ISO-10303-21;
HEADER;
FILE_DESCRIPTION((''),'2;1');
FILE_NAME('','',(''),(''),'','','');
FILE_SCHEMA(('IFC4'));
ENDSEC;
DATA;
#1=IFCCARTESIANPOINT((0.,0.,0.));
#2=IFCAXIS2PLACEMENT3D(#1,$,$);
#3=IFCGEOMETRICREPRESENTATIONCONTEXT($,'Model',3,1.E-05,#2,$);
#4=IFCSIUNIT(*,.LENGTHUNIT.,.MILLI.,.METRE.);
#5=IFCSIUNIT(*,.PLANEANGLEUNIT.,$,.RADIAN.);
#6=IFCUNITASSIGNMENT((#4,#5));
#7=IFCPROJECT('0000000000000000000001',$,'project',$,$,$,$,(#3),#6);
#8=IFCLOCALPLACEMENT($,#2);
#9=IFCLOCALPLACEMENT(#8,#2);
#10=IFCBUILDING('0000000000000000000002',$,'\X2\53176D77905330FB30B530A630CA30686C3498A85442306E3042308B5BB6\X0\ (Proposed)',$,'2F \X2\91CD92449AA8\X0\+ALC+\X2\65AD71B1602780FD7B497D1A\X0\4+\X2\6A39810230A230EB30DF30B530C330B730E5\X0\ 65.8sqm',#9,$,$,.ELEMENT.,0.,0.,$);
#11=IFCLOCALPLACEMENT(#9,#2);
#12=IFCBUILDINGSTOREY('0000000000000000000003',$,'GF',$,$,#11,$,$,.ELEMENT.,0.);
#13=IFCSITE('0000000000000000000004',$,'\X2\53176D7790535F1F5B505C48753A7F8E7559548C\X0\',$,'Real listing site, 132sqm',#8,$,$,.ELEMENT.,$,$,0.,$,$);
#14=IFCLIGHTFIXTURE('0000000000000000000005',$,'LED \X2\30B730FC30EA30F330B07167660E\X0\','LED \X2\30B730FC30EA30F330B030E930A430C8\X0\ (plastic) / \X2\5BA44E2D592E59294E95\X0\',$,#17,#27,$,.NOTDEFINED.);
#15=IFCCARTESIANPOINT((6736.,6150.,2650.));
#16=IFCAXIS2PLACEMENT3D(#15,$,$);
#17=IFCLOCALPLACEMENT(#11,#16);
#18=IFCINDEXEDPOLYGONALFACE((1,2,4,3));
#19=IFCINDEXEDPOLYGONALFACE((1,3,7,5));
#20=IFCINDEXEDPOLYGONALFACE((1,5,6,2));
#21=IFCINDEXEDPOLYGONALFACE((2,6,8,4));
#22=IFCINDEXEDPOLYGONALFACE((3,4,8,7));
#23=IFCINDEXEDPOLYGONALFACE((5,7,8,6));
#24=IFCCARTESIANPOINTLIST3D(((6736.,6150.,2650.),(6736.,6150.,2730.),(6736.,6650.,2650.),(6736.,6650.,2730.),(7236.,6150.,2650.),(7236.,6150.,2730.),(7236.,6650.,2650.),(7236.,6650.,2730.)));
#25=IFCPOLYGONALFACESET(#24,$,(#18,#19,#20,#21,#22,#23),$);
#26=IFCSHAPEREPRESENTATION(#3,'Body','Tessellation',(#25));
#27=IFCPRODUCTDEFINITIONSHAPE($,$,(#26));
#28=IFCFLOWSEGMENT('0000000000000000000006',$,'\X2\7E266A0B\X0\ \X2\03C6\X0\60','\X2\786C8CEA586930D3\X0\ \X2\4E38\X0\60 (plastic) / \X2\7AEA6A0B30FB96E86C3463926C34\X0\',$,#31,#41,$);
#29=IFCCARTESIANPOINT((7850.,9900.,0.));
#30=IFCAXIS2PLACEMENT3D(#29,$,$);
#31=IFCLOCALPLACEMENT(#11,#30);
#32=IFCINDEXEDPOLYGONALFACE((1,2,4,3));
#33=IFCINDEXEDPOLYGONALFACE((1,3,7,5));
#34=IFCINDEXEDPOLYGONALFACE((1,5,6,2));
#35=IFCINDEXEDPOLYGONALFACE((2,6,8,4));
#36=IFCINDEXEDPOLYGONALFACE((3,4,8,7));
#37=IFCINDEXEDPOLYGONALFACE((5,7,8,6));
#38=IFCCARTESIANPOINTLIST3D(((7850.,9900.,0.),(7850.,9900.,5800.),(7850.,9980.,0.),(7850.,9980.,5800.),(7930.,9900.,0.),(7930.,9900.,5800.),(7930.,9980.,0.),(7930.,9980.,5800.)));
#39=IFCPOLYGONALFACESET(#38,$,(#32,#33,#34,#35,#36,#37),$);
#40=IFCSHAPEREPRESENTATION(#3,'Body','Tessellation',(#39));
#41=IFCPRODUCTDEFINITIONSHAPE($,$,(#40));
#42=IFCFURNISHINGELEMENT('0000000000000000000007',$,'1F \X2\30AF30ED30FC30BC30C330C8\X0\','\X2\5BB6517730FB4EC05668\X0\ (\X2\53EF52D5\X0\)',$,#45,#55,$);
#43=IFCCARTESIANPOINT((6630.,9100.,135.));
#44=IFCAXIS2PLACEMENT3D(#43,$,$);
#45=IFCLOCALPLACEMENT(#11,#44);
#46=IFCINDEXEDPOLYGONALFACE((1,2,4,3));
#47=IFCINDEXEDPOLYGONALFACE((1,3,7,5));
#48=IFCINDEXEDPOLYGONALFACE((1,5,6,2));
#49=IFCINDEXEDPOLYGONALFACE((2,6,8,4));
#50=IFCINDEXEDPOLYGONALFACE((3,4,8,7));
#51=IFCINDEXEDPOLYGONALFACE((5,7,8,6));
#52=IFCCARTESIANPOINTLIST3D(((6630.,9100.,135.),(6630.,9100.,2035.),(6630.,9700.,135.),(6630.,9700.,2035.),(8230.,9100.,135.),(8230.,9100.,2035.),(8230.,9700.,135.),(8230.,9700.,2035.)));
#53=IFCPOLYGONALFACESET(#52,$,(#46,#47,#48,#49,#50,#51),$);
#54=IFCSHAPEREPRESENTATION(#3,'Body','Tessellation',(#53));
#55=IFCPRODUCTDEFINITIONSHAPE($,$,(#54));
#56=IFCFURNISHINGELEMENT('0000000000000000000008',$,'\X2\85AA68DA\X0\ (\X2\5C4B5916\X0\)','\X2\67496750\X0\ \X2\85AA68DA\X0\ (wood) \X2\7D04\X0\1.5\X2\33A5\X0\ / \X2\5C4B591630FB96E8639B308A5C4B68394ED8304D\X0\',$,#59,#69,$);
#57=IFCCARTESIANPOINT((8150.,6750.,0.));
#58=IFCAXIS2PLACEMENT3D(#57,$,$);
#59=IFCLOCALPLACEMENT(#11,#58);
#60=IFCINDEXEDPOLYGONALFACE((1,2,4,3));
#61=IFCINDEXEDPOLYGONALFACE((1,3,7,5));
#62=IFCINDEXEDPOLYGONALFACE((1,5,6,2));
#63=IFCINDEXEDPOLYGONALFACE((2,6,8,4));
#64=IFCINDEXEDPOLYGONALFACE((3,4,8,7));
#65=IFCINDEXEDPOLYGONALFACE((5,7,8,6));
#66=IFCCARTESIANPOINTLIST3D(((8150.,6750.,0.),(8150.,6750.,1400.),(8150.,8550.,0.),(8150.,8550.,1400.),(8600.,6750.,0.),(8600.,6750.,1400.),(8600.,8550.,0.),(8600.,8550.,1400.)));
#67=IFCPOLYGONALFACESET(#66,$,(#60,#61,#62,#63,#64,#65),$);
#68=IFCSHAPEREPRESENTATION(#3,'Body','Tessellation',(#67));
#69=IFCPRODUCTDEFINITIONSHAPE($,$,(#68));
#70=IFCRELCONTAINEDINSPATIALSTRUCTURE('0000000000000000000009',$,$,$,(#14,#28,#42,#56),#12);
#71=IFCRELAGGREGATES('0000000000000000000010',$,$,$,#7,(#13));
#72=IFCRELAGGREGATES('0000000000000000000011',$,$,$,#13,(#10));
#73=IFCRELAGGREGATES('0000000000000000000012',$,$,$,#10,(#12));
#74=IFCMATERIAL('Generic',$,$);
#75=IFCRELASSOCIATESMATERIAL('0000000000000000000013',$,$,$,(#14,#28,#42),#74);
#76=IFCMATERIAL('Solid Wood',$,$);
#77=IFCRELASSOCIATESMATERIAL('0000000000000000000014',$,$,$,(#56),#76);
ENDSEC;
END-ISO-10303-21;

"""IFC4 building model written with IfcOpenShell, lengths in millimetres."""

from ifc_helpers import new_model, si_unit, frame, frame_2d, origin, place, context, project, spatial, rectangle, extrude, material, element, save


model = new_model("IFC4")

# Units and contexts
model_context = context("Model", 3, precision=1e-05, world=origin())
ifc_project = project(units=[si_unit("LENGTHUNIT", "METRE", prefix="MILLI"), si_unit("PLANEANGLEUNIT", "RADIAN")], contexts=[model_context])

# Site, building, storey
site_placement = place(None, origin())
site = spatial("IfcSite", under=ifc_project, at=site_placement, Name="北海道弟子屈町美留和", ObjectType="Real listing site, 132sqm", CompositionType="ELEMENT", RefElevation=0.0)
building_placement = place(site_placement, origin())
building = spatial("IfcBuilding", under=site, at=building_placement, Name="北海道・サウナと水風呂のある家 (Proposed)", ObjectType="2F 重鉄骨+ALC+断熱性能等級4+樹脂アルミサッシュ 65.8sqm", CompositionType="ELEMENT", ElevationOfRefHeight=0.0, ElevationOfTerrain=0.0)
storey_placement = place(building_placement, origin())
storey = spatial("IfcBuildingStorey", under=building, at=storey_placement, Name="GF", CompositionType="ELEMENT", Elevation=0.0)

# Shared definitions
ifc_material_1 = material(Name="Solid Wood")

# Shared definitions
ifc_material_2 = material(Name="Generic")

# Light fixture
light_fixture_placement = place(storey_placement, frame((6736.0, 6150.0, 2650.0)))
element("IfcLightFixture", 1, at=light_fixture_placement, inside=storey, material=ifc_material_2, Name="LED シーリング照明", Description="LED シーリングライト (plastic) / 室中央天井", PredefinedType="NOTDEFINED", context=model_context, shape_type="SweptSolid", body=[
    extrude(rectangle(XDim=500.0, YDim=500.0, at=frame_2d((250.0, 250.0))), frame((6736.0, 6150.0, 2650.0)), (0.0, 0.0, 1.0), 80.0),
])

# Flow segment
flow_segment_placement = place(storey_placement, frame((7850.0, 9900.0, 0.0)))
element("IfcFlowSegment", 2, at=flow_segment_placement, inside=storey, material=ifc_material_2, Name="縦樋 φ60", Description="硬質塩ビ 丸60 (plastic) / 竪樋・雨水排水", context=model_context, shape_type="SweptSolid", body=[
    extrude(rectangle(XDim=80.0, YDim=80.0, at=frame_2d((40.0, 40.0))), frame((7850.0, 9900.0, 0.0)), (0.0, 0.0, 1.0), 5800.0),
])

# Furnishing elements
furnishing_1_placement = place(storey_placement, frame((6630.0, 9100.0, 135.0)))
element("IfcFurnishingElement", 3, at=furnishing_1_placement, inside=storey, material=ifc_material_2, Name="1F クローゼット", Description="家具・什器 (可動)", context=model_context, shape_type="SweptSolid", body=[
    extrude(rectangle(XDim=1600.0, YDim=600.0, at=frame_2d((800.0, 300.0))), frame((6630.0, 9100.0, 135.0)), (0.0, 0.0, 1.0), 1900.0),
])
furnishing_2_placement = place(storey_placement, frame((8150.0, 6750.0, 0.0)))
element("IfcFurnishingElement", 4, at=furnishing_2_placement, inside=storey, material=ifc_material_1, Name="薪棚 (屋外)", Description="杉材 薪棚 (wood) 約1.5㎥ / 屋外・雨掛り屋根付き", context=model_context, shape_type="SweptSolid", body=[
    extrude(rectangle(XDim=450.0, YDim=1800.0, at=frame_2d((225.0, 900.0))), frame((8150.0, 6750.0, 0.0)), (0.0, 0.0, 1.0), 1400.0),
])

save(model, "model.ifc")
